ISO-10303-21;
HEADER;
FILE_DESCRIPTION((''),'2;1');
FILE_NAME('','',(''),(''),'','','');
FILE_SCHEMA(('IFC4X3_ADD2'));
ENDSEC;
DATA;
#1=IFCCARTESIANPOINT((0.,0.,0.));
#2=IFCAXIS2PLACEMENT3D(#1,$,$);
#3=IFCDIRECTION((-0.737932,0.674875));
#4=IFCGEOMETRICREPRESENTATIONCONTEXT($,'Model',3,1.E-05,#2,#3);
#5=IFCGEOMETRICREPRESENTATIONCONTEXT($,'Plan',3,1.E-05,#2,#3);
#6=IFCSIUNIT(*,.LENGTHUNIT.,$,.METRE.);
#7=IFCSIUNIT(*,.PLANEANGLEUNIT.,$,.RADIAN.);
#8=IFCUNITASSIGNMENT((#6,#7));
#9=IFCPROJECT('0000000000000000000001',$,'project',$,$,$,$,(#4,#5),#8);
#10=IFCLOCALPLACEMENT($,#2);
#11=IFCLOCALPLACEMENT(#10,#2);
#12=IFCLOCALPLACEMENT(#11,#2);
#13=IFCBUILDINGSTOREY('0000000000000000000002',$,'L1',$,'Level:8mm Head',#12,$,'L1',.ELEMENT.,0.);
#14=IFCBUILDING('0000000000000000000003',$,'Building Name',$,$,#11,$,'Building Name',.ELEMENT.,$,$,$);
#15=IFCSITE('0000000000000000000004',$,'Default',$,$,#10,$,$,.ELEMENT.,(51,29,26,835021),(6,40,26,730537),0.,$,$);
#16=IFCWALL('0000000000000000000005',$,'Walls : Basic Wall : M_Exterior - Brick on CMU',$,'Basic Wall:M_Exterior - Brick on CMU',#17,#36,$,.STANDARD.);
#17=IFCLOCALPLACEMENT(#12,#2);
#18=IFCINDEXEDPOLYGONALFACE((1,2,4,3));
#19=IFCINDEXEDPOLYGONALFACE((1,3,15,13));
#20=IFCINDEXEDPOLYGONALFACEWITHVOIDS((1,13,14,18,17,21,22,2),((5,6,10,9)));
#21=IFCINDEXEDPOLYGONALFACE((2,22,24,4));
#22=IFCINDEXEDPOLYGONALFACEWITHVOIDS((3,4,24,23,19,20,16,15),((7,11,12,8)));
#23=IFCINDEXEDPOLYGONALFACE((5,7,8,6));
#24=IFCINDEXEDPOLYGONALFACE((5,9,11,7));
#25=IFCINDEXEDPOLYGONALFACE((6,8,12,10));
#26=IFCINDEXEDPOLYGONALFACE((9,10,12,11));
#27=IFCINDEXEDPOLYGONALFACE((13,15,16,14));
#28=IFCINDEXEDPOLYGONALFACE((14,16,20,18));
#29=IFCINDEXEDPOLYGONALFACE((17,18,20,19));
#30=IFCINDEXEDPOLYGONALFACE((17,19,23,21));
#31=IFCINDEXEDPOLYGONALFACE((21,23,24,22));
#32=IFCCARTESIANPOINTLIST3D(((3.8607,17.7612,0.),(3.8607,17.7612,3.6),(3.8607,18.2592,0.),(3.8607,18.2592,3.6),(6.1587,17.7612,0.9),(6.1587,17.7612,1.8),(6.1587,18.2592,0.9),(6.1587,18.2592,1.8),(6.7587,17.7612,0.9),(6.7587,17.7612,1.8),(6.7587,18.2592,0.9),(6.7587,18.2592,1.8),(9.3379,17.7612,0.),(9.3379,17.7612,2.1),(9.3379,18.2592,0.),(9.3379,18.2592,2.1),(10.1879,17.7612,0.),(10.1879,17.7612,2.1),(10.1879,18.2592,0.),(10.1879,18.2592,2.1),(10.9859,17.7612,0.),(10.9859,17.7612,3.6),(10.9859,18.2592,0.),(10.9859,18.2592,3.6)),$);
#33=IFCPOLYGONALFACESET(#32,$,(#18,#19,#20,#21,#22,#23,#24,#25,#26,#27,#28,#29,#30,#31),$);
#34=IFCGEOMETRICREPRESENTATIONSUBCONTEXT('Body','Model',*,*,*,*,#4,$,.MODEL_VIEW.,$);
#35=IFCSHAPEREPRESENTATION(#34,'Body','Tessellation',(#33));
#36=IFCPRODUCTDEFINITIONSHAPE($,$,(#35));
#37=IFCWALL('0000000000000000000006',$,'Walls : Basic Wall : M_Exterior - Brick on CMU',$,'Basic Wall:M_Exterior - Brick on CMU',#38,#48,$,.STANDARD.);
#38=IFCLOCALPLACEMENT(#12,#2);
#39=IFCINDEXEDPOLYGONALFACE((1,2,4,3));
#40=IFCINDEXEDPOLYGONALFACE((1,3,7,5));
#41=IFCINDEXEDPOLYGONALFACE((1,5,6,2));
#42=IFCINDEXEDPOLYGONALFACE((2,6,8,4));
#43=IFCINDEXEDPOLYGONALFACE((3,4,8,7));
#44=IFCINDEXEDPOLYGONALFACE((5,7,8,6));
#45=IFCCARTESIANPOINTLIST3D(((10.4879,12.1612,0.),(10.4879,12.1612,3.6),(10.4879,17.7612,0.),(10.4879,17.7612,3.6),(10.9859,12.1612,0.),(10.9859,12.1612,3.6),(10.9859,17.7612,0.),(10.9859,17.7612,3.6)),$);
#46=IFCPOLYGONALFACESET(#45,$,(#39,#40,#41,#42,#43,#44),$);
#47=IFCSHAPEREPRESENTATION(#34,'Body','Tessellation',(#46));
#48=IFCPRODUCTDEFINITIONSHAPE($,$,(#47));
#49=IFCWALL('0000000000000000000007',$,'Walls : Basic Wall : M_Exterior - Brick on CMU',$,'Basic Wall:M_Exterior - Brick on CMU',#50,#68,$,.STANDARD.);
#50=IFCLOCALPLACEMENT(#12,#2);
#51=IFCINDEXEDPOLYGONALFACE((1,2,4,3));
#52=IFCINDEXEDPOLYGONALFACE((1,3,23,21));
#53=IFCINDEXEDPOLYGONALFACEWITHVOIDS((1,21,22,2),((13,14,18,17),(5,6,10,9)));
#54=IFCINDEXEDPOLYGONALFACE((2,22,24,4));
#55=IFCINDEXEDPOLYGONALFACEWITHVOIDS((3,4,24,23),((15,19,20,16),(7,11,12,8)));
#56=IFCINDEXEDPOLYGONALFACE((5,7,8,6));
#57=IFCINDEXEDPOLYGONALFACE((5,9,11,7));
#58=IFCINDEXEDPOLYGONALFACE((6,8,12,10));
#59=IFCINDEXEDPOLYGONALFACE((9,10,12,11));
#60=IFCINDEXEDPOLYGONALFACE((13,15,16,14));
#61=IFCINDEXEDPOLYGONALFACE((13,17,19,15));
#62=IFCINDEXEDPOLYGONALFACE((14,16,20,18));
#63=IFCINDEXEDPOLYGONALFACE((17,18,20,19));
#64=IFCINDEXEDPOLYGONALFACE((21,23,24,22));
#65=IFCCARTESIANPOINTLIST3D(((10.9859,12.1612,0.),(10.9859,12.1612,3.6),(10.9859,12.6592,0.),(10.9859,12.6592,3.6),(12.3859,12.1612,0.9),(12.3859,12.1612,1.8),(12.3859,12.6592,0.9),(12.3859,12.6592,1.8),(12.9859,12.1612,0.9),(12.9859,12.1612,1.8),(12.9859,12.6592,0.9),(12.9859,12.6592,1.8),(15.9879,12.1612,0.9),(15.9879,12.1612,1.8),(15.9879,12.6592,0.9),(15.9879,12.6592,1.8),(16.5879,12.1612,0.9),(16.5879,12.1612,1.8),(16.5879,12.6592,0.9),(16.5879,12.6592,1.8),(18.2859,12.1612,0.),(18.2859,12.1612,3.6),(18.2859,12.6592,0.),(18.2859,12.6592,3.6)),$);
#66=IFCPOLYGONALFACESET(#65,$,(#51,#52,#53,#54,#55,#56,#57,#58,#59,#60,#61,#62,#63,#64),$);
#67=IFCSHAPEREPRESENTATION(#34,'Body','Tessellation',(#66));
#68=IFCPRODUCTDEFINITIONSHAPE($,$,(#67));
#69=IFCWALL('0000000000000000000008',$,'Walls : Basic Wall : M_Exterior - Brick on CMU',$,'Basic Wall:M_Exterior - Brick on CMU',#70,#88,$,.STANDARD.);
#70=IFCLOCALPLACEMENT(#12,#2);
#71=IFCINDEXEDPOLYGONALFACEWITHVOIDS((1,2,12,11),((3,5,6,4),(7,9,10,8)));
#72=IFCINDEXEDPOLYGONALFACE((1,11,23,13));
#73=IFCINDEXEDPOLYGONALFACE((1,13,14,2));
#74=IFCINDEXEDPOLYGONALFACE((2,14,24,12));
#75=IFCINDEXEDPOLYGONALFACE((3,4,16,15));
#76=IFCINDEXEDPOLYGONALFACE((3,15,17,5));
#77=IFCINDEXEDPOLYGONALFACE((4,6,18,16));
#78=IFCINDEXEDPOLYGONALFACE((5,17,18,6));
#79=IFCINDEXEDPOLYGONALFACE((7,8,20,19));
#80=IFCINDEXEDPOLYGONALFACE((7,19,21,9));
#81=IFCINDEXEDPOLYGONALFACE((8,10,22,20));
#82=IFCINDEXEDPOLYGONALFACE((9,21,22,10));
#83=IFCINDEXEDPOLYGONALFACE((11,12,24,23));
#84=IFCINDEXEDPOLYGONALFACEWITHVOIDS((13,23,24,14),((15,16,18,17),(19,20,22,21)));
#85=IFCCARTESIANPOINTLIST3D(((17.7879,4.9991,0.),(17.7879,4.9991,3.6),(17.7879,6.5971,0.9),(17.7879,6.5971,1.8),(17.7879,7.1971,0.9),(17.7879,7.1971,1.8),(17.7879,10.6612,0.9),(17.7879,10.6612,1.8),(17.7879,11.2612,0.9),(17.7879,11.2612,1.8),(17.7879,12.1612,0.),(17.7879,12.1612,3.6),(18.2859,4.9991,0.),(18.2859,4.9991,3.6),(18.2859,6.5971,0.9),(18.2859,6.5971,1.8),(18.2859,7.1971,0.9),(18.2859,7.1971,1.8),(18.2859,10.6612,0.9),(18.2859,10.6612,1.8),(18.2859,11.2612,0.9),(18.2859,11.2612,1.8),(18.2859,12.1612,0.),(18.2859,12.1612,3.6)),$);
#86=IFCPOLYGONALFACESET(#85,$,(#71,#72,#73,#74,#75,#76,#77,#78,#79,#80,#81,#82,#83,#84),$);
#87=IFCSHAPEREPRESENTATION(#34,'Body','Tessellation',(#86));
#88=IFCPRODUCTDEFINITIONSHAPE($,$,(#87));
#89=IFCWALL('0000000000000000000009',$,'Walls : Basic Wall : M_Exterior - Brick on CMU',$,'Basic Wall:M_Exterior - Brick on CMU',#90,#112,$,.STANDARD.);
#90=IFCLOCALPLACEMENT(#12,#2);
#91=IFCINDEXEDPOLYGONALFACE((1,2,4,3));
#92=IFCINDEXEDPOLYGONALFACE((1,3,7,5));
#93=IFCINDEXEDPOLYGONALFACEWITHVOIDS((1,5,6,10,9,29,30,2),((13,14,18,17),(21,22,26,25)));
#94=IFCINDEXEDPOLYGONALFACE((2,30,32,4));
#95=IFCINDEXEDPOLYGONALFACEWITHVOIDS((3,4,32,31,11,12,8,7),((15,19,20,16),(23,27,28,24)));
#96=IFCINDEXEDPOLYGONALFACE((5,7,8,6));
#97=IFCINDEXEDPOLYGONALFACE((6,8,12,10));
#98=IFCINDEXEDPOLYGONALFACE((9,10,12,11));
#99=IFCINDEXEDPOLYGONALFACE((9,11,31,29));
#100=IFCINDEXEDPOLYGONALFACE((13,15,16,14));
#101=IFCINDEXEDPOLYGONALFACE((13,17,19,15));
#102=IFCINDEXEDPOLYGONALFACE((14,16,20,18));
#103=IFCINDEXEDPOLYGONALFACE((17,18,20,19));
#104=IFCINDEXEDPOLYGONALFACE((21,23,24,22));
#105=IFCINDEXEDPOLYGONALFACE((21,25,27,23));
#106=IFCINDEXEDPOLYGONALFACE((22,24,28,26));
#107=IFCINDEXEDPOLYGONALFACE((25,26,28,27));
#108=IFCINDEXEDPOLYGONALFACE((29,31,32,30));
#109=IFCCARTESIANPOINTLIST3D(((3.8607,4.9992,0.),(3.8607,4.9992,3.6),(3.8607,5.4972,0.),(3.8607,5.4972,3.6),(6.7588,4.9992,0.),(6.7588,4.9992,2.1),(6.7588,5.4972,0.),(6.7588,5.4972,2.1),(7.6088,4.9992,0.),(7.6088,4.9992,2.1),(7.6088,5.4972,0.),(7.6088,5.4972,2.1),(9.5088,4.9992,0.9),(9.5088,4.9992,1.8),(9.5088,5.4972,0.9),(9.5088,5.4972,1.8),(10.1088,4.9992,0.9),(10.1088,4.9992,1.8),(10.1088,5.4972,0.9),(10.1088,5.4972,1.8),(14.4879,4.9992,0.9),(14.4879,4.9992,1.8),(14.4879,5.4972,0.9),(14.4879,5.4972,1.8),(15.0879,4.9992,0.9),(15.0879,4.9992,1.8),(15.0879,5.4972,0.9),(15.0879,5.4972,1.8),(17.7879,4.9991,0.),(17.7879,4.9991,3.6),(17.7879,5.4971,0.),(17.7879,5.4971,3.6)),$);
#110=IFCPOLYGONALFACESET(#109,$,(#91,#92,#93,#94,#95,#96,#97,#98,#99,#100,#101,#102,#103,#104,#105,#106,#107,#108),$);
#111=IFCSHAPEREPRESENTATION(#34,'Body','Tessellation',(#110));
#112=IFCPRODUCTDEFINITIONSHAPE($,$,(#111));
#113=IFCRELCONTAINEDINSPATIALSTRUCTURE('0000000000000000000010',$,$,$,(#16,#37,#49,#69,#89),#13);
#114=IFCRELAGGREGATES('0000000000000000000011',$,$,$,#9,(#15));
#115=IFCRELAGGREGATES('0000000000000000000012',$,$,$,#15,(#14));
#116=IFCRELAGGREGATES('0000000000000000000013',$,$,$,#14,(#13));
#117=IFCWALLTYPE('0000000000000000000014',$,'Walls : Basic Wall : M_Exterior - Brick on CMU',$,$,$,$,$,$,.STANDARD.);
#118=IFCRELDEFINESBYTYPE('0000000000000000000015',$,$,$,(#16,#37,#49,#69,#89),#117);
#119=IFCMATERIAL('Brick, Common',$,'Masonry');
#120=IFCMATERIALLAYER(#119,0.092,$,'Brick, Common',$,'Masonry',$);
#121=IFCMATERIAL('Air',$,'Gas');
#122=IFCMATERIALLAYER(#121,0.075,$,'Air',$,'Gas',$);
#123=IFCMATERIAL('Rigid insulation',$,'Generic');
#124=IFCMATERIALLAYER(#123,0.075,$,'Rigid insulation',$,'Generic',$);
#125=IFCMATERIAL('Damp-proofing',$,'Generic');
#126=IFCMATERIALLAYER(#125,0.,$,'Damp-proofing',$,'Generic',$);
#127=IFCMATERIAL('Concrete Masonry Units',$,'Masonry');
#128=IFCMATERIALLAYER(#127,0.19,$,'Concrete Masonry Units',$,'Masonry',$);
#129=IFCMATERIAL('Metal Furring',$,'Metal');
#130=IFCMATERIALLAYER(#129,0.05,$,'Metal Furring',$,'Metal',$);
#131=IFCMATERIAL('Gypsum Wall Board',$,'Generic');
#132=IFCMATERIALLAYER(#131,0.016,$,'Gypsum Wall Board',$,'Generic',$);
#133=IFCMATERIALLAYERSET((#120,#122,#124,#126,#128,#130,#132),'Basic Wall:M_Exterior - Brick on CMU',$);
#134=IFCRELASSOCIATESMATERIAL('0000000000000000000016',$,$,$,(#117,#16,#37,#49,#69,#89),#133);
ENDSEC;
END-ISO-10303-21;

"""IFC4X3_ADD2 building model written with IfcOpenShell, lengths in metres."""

from ifc_helpers import new_model, si_unit, direction, frame, frame_2d, origin, origin_2d_with_axis, place, context, subcontext, project, spatial, rectangle, extrude, material, layer, layer_set, type_object, element, save


model = new_model("IFC4X3_ADD2")

# Units and contexts
model_context = context("Model", 3, precision=1e-05, world=origin(), true_north=direction((-0.737932, 0.674875)))
plan_context = context("Plan", 3, precision=1e-05, world=origin(), true_north=direction((-0.737932, 0.674875)))
body_context = subcontext(model_context, "Body", "Model", "MODEL_VIEW")
ifc_project = project(units=[si_unit("LENGTHUNIT", "METRE"), si_unit("PLANEANGLEUNIT", "RADIAN")], contexts=[model_context, plan_context])

# Site, building, storey
site_placement = place(None, origin())
site = spatial("IfcSite", under=ifc_project, at=site_placement, Name="Default", CompositionType="ELEMENT", RefLatitude=(51, 29, 26, 835021), RefLongitude=(6, 40, 26, 730537), RefElevation=0.0)
building_placement = place(site_placement, origin())
building = spatial("IfcBuilding", under=site, at=building_placement, Name="Building Name", LongName="Building Name", CompositionType="ELEMENT")
storey_placement = place(building_placement, origin())
storey = spatial("IfcBuildingStorey", under=building, at=storey_placement, Name="L1", ObjectType="Level:8mm Head", LongName="L1", CompositionType="ELEMENT", Elevation=0.0)

# Wall, openings
ifc_material_1 = material(Name="Brick, Common", Category="Masonry")
ifc_layer_1 = layer(ifc_material_1, 0.092, Name="Brick, Common", Category="Masonry")
ifc_material_2 = material(Name="Air", Category="Gas")
ifc_layer_2 = layer(ifc_material_2, 0.075, Name="Air", Category="Gas")
ifc_material_3 = material(Name="Rigid insulation", Category="Generic")
ifc_layer_3 = layer(ifc_material_3, 0.075, Name="Rigid insulation", Category="Generic")
ifc_material_4 = material(Name="Damp-proofing", Category="Generic")
ifc_layer_4 = layer(ifc_material_4, 0.0, Name="Damp-proofing", Category="Generic")
ifc_material_5 = material(Name="Concrete Masonry Units", Category="Masonry")
ifc_layer_5 = layer(ifc_material_5, 0.19, Name="Concrete Masonry Units", Category="Masonry")
ifc_material_6 = material(Name="Metal Furring", Category="Metal")
ifc_layer_6 = layer(ifc_material_6, 0.05, Name="Metal Furring", Category="Metal")
ifc_material_7 = material(Name="Gypsum Wall Board", Category="Generic")
ifc_layer_7 = layer(ifc_material_7, 0.016, Name="Gypsum Wall Board", Category="Generic")
ifc_layer_set_1 = layer_set([ifc_layer_1, ifc_layer_2, ifc_layer_3, ifc_layer_4, ifc_layer_5, ifc_layer_6, ifc_layer_7], Name="Basic Wall:M_Exterior - Brick on CMU")
wall_type = type_object("IfcWallType", Name="Walls : Basic Wall : M_Exterior - Brick on CMU", PredefinedType="STANDARD", material=ifc_layer_set_1)
wall_1_placement = place(storey_placement, frame((3.8607, 18.0102, 0.0)))
wall_1 = element("IfcWall", 1, at=wall_1_placement, inside=storey, type_object=wall_type, material=ifc_layer_set_1, Name="Walls : Basic Wall : M_Exterior - Brick on CMU", ObjectType="Basic Wall:M_Exterior - Brick on CMU", PredefinedType="STANDARD", context=body_context, shape_type="SweptSolid", body=[
    extrude(rectangle(XDim=7.1251, YDim=0.498, at=frame_2d((3.5626, 0.0), x_axis=(-1.0, 0.0))), origin(), (0.0, 0.0, 1.0), 3.6),
])
opening_1_placement = place(wall_1_placement, frame((-3.8607, -18.0102, 0.0)))
element("IfcOpeningElement", 2, at=opening_1_placement, cuts=wall_1, PredefinedType="OPENING", context=body_context, shape_type="SweptSolid", body=[
    extrude(rectangle(XDim=2.1, YDim=0.85, at=frame_2d((0.0, 0.0), x_axis=(0.0, 1.0))), frame((9.7629, 16.2372, 1.05), z_axis=(0.0, 1.0, 0.0), x_axis=(-1.0, 0.0, 0.0)), (0.0, 0.0, 1.0), 3.048),
])
opening_2_placement = place(wall_1_placement, frame((-3.8607, -18.0102, 0.9)))
element("IfcOpeningElement", 3, at=opening_2_placement, cuts=wall_1, PredefinedType="OPENING", context=body_context, shape_type="SweptSolid", body=[
    extrude(rectangle(XDim=0.9, YDim=0.6, at=origin_2d_with_axis()), frame((6.4587, 16.2372, 0.45), z_axis=(0.0, 1.0, 0.0), x_axis=(0.0, 0.0, -1.0)), (0.0, 0.0, 1.0), 3.048),
])

# Wall
wall_2_placement = place(storey_placement, frame((10.7369, 17.7612, 0.0), z_axis=(0.0, 0.0, 1.0), x_axis=(0.0, -1.0, 0.0)))
element("IfcWall", 4, at=wall_2_placement, inside=storey, type_object=wall_type, material=ifc_layer_set_1, Name="Walls : Basic Wall : M_Exterior - Brick on CMU", ObjectType="Basic Wall:M_Exterior - Brick on CMU", PredefinedType="STANDARD", context=body_context, shape_type="SweptSolid", body=[
    extrude(rectangle(XDim=5.6, YDim=0.498, at=frame_2d((2.8, 0.0), x_axis=(-1.0, 0.0))), origin(), (0.0, 0.0, 1.0), 3.6),
])

# Walls, openings
wall_3_placement = place(storey_placement, frame((10.9859, 12.4102, 0.0)))
wall_3 = element("IfcWall", 5, at=wall_3_placement, inside=storey, type_object=wall_type, material=ifc_layer_set_1, Name="Walls : Basic Wall : M_Exterior - Brick on CMU", ObjectType="Basic Wall:M_Exterior - Brick on CMU", PredefinedType="STANDARD", context=body_context, shape_type="SweptSolid", body=[
    extrude(rectangle(XDim=7.3, YDim=0.498, at=frame_2d((3.65, 0.0), x_axis=(-1.0, 0.0))), origin(), (0.0, 0.0, 1.0), 3.6),
])
opening_3_placement = place(wall_3_placement, frame((-10.9859, -12.4102, 0.9)))
element("IfcOpeningElement", 6, at=opening_3_placement, cuts=wall_3, PredefinedType="OPENING", context=body_context, shape_type="SweptSolid", body=[
    extrude(rectangle(XDim=0.9, YDim=0.6, at=frame_2d((0.0, 0.0), x_axis=(1.0, 0.0))), frame((16.2879, 10.6372, 0.45), z_axis=(0.0, 1.0, 0.0), x_axis=(0.0, 0.0, -1.0)), (0.0, 0.0, 1.0), 3.048),
])
opening_4_placement = place(wall_3_placement, frame((-10.9859, -12.4102, 0.9)))
element("IfcOpeningElement", 7, at=opening_4_placement, cuts=wall_3, PredefinedType="OPENING", context=body_context, shape_type="SweptSolid", body=[
    extrude(rectangle(XDim=0.9, YDim=0.6, at=frame_2d((0.0, 0.0), x_axis=(1.0, 0.0))), frame((12.6859, 10.6372, 0.45), z_axis=(0.0, 1.0, 0.0), x_axis=(0.0, 0.0, -1.0)), (0.0, 0.0, 1.0), 3.048),
])
wall_4_placement = place(storey_placement, frame((18.0369, 12.1612, 0.0), z_axis=(0.0, 0.0, 1.0), x_axis=(0.0, -1.0, 0.0)))
wall_4 = element("IfcWall", 8, at=wall_4_placement, inside=storey, type_object=wall_type, material=ifc_layer_set_1, Name="Walls : Basic Wall : M_Exterior - Brick on CMU", ObjectType="Basic Wall:M_Exterior - Brick on CMU", PredefinedType="STANDARD", context=body_context, shape_type="SweptSolid", body=[
    extrude(rectangle(XDim=7.1621, YDim=0.498, at=frame_2d((3.581, 0.0), x_axis=(-1.0, 0.0))), origin(), (0.0, 0.0, 1.0), 3.6),
])
opening_5_placement = place(wall_4_placement, frame((12.1612, -18.0369, 0.9)))
element("IfcOpeningElement", 9, at=opening_5_placement, cuts=wall_4, PredefinedType="OPENING", context=body_context, shape_type="SweptSolid", body=[
    extrude(rectangle(XDim=0.9, YDim=0.6, at=frame_2d((0.0, 0.0), x_axis=(1.0, 0.0))), frame((-6.8971, 16.2639, 0.45), z_axis=(0.0, 1.0, 0.0), x_axis=(0.0, 0.0, -1.0)), (0.0, 0.0, 1.0), 3.048),
])
opening_6_placement = place(wall_4_placement, frame((12.1612, -18.0369, 0.9)))
element("IfcOpeningElement", 10, at=opening_6_placement, cuts=wall_4, PredefinedType="OPENING", context=body_context, shape_type="SweptSolid", body=[
    extrude(rectangle(XDim=0.9, YDim=0.6, at=frame_2d((0.0, 0.0), x_axis=(1.0, 0.0))), frame((-10.9612, 16.2639, 0.45), z_axis=(0.0, 1.0, 0.0), x_axis=(0.0, 0.0, -1.0)), (0.0, 0.0, 1.0), 3.048),
])
wall_5_placement = place(storey_placement, frame((17.7879, 5.2481, 0.0), z_axis=(0.0, 0.0, 1.0), x_axis=(-1.0, 0.000006, 0.0)))
wall_5 = element("IfcWall", 11, at=wall_5_placement, inside=storey, type_object=wall_type, material=ifc_layer_set_1, Name="Walls : Basic Wall : M_Exterior - Brick on CMU", ObjectType="Basic Wall:M_Exterior - Brick on CMU", PredefinedType="STANDARD", context=body_context, shape_type="SweptSolid", body=[
    extrude(rectangle(XDim=13.9271, YDim=0.498, at=frame_2d((6.9636, 0.0), x_axis=(-1.0, 0.0))), origin(), (0.0, 0.0, 1.0), 3.6),
])
opening_7_placement = place(wall_5_placement, frame((17.7878, 5.2484, 0.0)))
element("IfcOpeningElement", 12, at=opening_7_placement, cuts=wall_5, PredefinedType="OPENING", context=body_context, shape_type="SweptSolid", body=[
    extrude(rectangle(XDim=2.1, YDim=0.85, at=frame_2d((0.0, 0.0), x_axis=(0.0, 1.0))), frame((-7.1837, -7.0212, 1.05), z_axis=(0.0, 1.0, 0.0), x_axis=(-1.0, 0.0, 0.0)), (0.0, 0.0, 1.0), 3.048),
])
opening_8_placement = place(wall_5_placement, frame((17.7878, 5.2484, 0.9)))
element("IfcOpeningElement", 13, at=opening_8_placement, cuts=wall_5, PredefinedType="OPENING", context=body_context, shape_type="SweptSolid", body=[
    extrude(rectangle(XDim=0.9, YDim=0.6, at=frame_2d((0.0, 0.0), x_axis=(1.0, 0.0))), frame((-9.8087, -7.0212, 0.45), z_axis=(0.0, 1.0, 0.0), x_axis=(0.0, 0.0, -1.0)), (0.0, 0.0, 1.0), 3.048),
])
opening_9_placement = place(wall_5_placement, frame((17.7878, 5.2484, 0.9)))
element("IfcOpeningElement", 14, at=opening_9_placement, cuts=wall_5, PredefinedType="OPENING", context=body_context, shape_type="SweptSolid", body=[
    extrude(rectangle(XDim=0.9, YDim=0.6, at=frame_2d((0.0, 0.0), x_axis=(1.0, 0.0))), frame((-14.7878, -7.0212, 0.45), z_axis=(0.0, 1.0, 0.0), x_axis=(0.0, 0.0, -1.0)), (0.0, 0.0, 1.0), 3.048),
])

save(model, "model.ifc")
